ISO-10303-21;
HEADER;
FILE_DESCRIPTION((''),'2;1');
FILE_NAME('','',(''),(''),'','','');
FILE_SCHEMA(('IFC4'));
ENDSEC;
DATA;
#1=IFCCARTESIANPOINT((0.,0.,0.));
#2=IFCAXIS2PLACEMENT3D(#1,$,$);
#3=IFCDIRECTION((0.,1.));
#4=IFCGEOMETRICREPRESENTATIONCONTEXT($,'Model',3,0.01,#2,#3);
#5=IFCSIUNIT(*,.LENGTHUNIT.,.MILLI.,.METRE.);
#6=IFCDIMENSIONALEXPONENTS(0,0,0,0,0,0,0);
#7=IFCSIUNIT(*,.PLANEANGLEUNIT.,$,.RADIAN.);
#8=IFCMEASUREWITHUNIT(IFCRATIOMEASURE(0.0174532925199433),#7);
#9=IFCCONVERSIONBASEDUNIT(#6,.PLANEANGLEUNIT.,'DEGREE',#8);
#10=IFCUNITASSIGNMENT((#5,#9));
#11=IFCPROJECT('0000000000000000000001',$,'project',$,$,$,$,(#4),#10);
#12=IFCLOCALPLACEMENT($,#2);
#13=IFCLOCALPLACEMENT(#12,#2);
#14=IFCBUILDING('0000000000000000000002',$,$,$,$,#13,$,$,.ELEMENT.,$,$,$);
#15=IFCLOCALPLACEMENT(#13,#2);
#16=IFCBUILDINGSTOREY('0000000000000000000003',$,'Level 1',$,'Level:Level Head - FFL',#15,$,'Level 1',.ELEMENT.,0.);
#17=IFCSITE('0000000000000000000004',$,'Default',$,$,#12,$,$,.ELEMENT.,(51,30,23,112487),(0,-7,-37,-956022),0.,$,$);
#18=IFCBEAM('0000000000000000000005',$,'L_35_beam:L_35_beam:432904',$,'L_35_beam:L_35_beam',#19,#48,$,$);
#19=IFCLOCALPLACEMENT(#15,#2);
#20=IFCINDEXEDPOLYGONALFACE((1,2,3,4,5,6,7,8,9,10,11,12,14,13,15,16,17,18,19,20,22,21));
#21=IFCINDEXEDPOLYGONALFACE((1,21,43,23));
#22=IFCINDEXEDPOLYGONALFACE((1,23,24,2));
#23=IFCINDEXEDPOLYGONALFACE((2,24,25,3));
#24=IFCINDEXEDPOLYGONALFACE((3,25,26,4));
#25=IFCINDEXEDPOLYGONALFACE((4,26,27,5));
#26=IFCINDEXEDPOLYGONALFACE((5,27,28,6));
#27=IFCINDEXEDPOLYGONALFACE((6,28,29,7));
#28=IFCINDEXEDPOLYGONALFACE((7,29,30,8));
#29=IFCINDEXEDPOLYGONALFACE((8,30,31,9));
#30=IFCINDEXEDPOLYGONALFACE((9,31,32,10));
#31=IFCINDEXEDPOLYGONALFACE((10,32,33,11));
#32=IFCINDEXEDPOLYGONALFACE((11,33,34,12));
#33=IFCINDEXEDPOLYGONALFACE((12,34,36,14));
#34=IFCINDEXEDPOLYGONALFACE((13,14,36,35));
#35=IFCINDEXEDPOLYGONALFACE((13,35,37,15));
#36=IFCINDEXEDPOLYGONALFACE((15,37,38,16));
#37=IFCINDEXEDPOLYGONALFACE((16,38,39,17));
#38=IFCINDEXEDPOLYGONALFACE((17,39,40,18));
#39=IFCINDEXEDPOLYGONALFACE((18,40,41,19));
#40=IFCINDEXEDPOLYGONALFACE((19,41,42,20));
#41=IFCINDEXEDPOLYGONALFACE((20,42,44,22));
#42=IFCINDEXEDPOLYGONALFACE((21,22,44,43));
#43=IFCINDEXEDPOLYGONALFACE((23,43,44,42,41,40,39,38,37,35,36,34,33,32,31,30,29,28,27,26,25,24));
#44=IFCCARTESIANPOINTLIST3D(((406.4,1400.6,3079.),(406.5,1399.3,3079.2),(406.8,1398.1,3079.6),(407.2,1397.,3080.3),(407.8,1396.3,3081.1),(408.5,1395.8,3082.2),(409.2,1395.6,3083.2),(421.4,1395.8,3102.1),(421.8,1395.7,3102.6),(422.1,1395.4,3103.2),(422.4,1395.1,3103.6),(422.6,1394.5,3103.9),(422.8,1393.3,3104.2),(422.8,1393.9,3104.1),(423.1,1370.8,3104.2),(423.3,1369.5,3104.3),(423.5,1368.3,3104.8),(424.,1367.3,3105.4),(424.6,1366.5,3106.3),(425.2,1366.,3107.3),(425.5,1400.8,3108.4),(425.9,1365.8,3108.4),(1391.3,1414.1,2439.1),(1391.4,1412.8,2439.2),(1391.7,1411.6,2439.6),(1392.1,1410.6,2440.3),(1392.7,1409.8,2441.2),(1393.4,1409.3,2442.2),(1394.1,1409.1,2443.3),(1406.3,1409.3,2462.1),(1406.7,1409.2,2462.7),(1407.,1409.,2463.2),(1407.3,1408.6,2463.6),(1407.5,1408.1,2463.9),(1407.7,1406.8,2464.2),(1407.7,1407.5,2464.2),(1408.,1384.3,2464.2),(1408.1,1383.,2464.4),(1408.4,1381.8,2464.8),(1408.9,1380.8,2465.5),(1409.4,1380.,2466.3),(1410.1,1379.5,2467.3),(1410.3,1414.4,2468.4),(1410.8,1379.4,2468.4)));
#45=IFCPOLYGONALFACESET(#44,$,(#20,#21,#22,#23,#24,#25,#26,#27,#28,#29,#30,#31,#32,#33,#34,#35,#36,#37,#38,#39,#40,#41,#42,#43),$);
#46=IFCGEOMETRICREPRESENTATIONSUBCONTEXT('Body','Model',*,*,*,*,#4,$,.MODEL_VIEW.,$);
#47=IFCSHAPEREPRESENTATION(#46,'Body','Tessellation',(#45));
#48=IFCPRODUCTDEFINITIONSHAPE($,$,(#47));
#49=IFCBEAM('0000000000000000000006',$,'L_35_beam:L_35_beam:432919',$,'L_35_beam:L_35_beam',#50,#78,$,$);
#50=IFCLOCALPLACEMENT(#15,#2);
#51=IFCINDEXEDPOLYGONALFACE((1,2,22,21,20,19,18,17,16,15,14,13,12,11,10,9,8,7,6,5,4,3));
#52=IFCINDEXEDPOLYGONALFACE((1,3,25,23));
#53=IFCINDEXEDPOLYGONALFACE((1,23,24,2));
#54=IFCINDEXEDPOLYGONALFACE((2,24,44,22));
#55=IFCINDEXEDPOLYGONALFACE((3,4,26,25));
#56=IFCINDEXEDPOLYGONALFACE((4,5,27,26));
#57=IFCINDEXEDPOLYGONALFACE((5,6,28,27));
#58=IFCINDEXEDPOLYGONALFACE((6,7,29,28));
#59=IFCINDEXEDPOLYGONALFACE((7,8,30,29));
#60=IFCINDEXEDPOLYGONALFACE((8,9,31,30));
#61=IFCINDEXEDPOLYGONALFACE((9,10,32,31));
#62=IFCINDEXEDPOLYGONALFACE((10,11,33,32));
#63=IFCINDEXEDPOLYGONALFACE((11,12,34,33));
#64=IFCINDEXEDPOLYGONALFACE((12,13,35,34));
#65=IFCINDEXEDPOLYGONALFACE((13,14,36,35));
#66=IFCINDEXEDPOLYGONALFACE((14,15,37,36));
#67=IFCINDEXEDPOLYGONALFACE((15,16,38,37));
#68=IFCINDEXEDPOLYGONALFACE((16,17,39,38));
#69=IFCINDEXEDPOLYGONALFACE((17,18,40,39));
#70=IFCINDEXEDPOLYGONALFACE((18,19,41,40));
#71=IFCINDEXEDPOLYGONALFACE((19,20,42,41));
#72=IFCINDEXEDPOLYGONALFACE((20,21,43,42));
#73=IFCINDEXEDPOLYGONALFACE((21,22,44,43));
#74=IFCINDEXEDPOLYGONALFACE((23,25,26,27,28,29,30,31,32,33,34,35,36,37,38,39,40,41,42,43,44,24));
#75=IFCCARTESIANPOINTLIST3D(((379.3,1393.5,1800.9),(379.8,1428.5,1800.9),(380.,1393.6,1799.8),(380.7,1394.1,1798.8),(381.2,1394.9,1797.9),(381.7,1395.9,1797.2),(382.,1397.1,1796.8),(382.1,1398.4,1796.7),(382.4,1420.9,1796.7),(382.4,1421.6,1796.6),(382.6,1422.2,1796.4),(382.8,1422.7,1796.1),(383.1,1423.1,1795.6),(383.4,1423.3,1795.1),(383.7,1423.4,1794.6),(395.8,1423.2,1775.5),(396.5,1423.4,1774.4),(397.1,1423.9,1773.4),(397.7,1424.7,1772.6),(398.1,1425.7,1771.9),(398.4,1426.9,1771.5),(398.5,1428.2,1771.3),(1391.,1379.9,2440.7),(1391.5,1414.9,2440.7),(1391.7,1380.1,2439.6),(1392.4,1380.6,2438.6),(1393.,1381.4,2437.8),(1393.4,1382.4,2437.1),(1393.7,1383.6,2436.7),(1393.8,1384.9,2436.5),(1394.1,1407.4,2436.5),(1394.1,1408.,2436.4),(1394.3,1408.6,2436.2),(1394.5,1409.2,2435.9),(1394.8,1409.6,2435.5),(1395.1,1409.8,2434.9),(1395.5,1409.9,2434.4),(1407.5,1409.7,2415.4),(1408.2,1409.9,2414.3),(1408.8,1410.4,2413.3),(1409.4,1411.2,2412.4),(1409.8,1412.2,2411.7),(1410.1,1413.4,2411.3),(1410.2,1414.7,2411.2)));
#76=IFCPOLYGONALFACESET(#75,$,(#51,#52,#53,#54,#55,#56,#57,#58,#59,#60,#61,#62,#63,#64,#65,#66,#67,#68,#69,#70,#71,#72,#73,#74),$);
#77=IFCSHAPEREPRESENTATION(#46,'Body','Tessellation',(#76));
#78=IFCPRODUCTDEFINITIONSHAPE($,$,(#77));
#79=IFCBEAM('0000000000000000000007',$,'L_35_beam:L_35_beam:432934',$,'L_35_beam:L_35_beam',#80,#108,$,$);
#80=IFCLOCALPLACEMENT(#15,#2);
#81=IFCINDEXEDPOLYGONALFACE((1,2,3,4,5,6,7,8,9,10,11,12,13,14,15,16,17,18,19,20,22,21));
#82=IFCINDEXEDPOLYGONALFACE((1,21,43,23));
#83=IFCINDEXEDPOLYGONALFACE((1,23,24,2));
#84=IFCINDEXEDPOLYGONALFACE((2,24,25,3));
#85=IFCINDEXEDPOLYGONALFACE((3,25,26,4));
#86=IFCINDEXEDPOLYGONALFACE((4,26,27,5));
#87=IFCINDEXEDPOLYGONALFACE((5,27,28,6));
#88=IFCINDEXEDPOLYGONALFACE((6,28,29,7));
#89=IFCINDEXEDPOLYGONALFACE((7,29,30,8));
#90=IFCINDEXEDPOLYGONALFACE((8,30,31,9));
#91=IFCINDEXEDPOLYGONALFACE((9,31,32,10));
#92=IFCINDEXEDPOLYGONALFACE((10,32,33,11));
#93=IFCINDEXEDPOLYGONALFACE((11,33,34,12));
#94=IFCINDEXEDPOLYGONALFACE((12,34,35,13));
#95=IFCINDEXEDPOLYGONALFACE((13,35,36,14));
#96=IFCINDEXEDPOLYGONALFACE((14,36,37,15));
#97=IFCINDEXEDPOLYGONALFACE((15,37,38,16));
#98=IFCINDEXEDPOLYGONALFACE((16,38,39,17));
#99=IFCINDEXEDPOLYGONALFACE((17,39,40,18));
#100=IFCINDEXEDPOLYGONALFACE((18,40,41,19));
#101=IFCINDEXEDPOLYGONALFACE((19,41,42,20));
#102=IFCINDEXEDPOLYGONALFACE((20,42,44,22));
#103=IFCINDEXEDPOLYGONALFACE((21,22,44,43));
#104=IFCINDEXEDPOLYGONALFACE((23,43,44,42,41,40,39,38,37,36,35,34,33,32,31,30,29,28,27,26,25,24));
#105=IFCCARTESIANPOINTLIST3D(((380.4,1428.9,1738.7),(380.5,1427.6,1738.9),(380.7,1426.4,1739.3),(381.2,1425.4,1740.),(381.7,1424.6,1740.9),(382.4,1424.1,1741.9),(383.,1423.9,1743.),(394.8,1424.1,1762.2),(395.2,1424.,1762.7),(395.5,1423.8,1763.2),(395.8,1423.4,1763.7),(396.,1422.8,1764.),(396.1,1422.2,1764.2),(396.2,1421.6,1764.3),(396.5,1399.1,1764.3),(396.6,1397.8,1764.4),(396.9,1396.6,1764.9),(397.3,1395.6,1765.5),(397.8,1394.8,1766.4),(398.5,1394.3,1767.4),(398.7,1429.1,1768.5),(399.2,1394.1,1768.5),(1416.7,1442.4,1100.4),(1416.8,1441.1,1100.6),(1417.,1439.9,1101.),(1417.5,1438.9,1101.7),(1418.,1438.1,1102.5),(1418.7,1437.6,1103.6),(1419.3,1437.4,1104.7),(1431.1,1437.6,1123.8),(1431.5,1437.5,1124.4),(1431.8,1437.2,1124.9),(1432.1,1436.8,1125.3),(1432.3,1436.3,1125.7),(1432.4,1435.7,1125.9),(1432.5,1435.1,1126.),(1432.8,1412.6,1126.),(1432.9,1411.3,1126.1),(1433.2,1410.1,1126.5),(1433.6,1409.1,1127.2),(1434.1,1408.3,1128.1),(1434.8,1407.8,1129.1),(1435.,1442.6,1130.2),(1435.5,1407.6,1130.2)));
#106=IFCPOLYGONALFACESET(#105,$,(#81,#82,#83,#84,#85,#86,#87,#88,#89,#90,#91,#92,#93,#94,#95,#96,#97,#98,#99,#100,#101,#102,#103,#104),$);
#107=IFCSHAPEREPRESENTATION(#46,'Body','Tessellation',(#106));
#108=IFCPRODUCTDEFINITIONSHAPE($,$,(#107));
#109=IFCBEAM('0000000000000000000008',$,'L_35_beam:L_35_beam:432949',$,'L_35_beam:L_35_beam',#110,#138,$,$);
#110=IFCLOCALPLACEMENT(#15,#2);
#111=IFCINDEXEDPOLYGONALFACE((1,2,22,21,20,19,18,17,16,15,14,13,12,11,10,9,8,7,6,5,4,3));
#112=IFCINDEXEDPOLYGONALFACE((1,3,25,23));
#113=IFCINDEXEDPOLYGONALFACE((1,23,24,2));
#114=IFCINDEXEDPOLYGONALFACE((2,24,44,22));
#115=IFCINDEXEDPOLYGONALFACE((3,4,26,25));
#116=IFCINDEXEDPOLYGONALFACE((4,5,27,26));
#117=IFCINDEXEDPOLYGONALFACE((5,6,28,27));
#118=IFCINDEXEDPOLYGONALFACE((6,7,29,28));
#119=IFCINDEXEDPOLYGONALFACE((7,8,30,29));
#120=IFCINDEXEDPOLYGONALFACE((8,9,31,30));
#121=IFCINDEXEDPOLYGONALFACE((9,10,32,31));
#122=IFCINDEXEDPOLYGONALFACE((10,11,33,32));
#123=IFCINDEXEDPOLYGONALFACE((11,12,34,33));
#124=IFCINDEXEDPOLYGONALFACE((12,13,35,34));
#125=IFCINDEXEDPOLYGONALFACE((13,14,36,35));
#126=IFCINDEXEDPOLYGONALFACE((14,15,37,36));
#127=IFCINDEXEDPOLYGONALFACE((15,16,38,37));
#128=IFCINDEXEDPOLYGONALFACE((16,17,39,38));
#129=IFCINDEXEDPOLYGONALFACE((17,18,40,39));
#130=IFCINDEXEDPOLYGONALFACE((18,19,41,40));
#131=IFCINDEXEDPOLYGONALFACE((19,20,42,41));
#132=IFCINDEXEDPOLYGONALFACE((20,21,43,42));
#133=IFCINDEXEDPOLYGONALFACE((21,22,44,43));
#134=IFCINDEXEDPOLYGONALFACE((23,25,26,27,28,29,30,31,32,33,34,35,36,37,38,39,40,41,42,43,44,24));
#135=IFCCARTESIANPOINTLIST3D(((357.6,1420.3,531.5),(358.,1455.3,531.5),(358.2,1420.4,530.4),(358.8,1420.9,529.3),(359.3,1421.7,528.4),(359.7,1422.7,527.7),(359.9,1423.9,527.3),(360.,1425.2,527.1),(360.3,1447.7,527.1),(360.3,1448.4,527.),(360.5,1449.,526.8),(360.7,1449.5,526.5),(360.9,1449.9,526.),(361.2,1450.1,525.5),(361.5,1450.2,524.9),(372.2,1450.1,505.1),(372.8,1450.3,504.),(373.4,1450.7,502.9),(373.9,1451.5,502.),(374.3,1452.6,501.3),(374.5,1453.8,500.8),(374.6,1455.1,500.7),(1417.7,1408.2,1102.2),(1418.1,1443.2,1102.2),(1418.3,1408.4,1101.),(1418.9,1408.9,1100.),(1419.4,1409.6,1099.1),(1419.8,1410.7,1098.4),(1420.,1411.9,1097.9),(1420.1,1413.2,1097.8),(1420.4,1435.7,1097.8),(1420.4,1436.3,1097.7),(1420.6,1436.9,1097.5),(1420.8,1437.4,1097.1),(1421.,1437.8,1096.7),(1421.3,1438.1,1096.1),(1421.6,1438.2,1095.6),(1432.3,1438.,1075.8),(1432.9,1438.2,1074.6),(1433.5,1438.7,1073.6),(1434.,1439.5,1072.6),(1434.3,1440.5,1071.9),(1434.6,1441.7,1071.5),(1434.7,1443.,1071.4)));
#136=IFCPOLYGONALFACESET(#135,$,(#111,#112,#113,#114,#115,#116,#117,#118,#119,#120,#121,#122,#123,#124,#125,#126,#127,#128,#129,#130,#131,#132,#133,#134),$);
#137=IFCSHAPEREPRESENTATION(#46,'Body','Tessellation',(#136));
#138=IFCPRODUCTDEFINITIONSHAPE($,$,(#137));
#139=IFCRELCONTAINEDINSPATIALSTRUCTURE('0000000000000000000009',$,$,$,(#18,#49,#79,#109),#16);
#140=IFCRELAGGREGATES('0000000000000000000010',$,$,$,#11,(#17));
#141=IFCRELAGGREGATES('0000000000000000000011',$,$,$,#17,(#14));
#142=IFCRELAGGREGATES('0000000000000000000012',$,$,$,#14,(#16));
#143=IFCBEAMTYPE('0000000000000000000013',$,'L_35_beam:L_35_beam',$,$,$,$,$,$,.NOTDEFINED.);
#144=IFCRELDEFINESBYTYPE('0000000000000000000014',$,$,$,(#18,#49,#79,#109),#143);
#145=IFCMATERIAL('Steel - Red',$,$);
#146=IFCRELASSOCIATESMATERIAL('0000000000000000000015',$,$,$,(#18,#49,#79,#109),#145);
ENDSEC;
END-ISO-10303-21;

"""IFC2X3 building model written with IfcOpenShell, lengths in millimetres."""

from ifc_helpers import new_model, entity, si_unit, converted_unit, direction, frame, frame_2d, origin, place, context, subcontext, project, spatial, polyline, circle_curve, parameter, trimmed, segment, composite_curve, outline, extrude, material, type_object, element, save


model = new_model("IFC2X3")

# Units and contexts
model_context = context("Model", 3, precision=0.01, world=origin(), true_north=direction((0.0, 1.0)))
body_context = subcontext(model_context, "Body", "Model", "MODEL_VIEW")
ifc_project = project(units=[si_unit("LENGTHUNIT", "METRE", prefix="MILLI"), converted_unit("PLANEANGLEUNIT", "DEGREE", entity("IfcRatioMeasure", 0.0174532925199433), si_unit("PLANEANGLEUNIT", "RADIAN"), dimensions=[0, 0, 0, 0, 0, 0, 0])], contexts=[model_context])

# Site, building, storey
site_placement = place(None, origin())
site = spatial("IfcSite", under=ifc_project, at=site_placement, Name="Default", CompositionType="ELEMENT", RefLatitude=(51, 30, 23, 112487), RefLongitude=(0, -7, -37, -956022), RefElevation=0.0)
building_placement = place(site_placement, origin())
building = spatial("IfcBuilding", under=site, at=building_placement, CompositionType="ELEMENT")
storey_placement = place(building_placement, origin())
storey = spatial("IfcBuildingStorey", under=building, at=storey_placement, Name="Level 1", ObjectType="Level:Level Head - FFL", LongName="Level 1", CompositionType="ELEMENT", Elevation=0.0)

# Beams
ifc_material_1 = material(Name="Steel - Red")
beam_type = type_object("IfcBeamType", Name="L_35_beam:L_35_beam", PredefinedType="NOTDEFINED")
beam_1_placement = place(storey_placement, frame((391.6, 1408.4, 3109.4), z_axis=(0.544781, 0.00748, 0.838545), x_axis=(0.838466, 0.011512, -0.544833)))
element("IfcBeam", 1, at=beam_1_placement, inside=storey, type_object=beam_type, material=ifc_material_1, Name="L_35_beam:L_35_beam:432904", ObjectType="L_35_beam:L_35_beam", context=body_context, shape_type="SweptSolid", body=[
    extrude(outline(composite_curve([segment(polyline([(-23.2, -11.8), (11.8, -11.8)]), True, "CONTINUOUS"), segment(polyline([(11.8, -11.8), (11.8, 23.2)]), True, "CONTINUOUS"), segment(trimmed(circle_curve(frame_2d((11.8, 18.2), x_axis=(0.0, 1.0)), 5.0), [parameter(0.0)], [parameter(90.0)], True, "PARAMETER"), True, "CONTINUOUS"), segment(polyline([(6.8, 18.2), (6.8, -4.3)]), True, "CONTINUOUS"), segment(trimmed(circle_curve(frame_2d((4.3, -4.3), x_axis=(1.0, 0.0)), 2.5), [parameter(270.0)], [parameter(0.0)], True, "PARAMETER"), False, "CONTINUOUS"), segment(polyline([(4.3, -6.8), (-18.2, -6.8)]), True, "CONTINUOUS"), segment(trimmed(circle_curve(frame_2d((-18.2, -11.8), x_axis=(0.0, 1.0)), 5.0), [parameter(0.0)], [parameter(90.0)], True, "PARAMETER"), True, "CONTINUOUS")], self_intersect=False)), frame((28.8, -19.8, 5.7), z_axis=(1.0, 0.0, 0.0), x_axis=(0.0, 0.0, 1.0)), (0.0, 0.0, 1.0), 1174.6),
])
beam_2_placement = place(storey_placement, frame((363.3, 1436.7, 1769.7), z_axis=(-0.534423, 0.007141, 0.845187), x_axis=(0.845111, -0.011293, 0.534471)))
element("IfcBeam", 2, at=beam_2_placement, inside=storey, type_object=beam_type, material=ifc_material_1, Name="L_35_beam:L_35_beam:432919", ObjectType="L_35_beam:L_35_beam", context=body_context, shape_type="SweptSolid", body=[
    extrude(outline(composite_curve([segment(polyline([(-23.2, -11.8), (11.8, -11.8)]), True, "CONTINUOUS"), segment(polyline([(11.8, -11.8), (11.8, 23.2)]), True, "CONTINUOUS"), segment(trimmed(circle_curve(frame_2d((11.8, 18.2), x_axis=(0.0, 1.0)), 5.0), [parameter(0.0)], [parameter(90.0)], True, "PARAMETER"), True, "CONTINUOUS"), segment(polyline([(6.8, 18.2), (6.8, -4.3)]), True, "CONTINUOUS"), segment(trimmed(circle_curve(frame_2d((4.3, -4.3), x_axis=(1.0, 0.0)), 2.5), [parameter(270.0)], [parameter(0.0)], True, "PARAMETER"), False, "CONTINUOUS"), segment(polyline([(4.3, -6.8), (-18.2, -6.8)]), True, "CONTINUOUS"), segment(trimmed(circle_curve(frame_2d((-18.2, -11.8), x_axis=(0.0, 1.0)), 5.0), [parameter(0.0)], [parameter(90.0)], True, "PARAMETER"), True, "CONTINUOUS")], self_intersect=False)), frame((30.7, -19.8, 5.7), z_axis=(1.0, 0.0, 0.0), x_axis=(0.0, 0.0, 1.0)), (0.0, 0.0, 1.0), 1197.1),
])
beam_3_placement = place(storey_placement, frame((363.3, 1436.7, 1769.7), z_axis=(0.524377, 0.006825, 0.851459), x_axis=(0.851387, 0.011081, -0.524421)))
element("IfcBeam", 3, at=beam_3_placement, inside=storey, type_object=beam_type, material=ifc_material_1, Name="L_35_beam:L_35_beam:432934", ObjectType="L_35_beam:L_35_beam", context=body_context, shape_type="SweptSolid", body=[
    extrude(outline(composite_curve([segment(polyline([(-23.2, -11.8), (11.8, -11.8)]), True, "CONTINUOUS"), segment(polyline([(11.8, -11.8), (11.8, 23.2)]), True, "CONTINUOUS"), segment(trimmed(circle_curve(frame_2d((11.8, 18.2), x_axis=(0.0, 1.0)), 5.0), [parameter(0.0)], [parameter(90.0)], True, "PARAMETER"), True, "CONTINUOUS"), segment(polyline([(6.8, 18.2), (6.8, -4.3)]), True, "CONTINUOUS"), segment(trimmed(circle_curve(frame_2d((4.3, -4.3), x_axis=(1.0, 0.0)), 2.5), [parameter(270.0)], [parameter(0.0)], True, "PARAMETER"), False, "CONTINUOUS"), segment(polyline([(4.3, -6.8), (-18.2, -6.8)]), True, "CONTINUOUS"), segment(trimmed(circle_curve(frame_2d((-18.2, -11.8), x_axis=(0.0, 1.0)), 5.0), [parameter(0.0)], [parameter(90.0)], True, "PARAMETER"), True, "CONTINUOUS")], self_intersect=False)), frame((30.6, -19.8, 5.7), z_axis=(1.0, 0.0, 0.0), x_axis=(0.0, 0.0, 1.0)), (0.0, 0.0, 1.0), 1217.2),
])
beam_4_placement = place(storey_placement, frame((336.5, 1463.5, 500.0), z_axis=(-0.473951, 0.005391, 0.880535), x_axis=(0.880478, -0.010015, 0.473982)))
element("IfcBeam", 4, at=beam_4_placement, inside=storey, type_object=beam_type, material=ifc_material_1, Name="L_35_beam:L_35_beam:432949", ObjectType="L_35_beam:L_35_beam", context=body_context, shape_type="SweptSolid", body=[
    extrude(outline(composite_curve([segment(polyline([(-23.2, -11.8), (11.8, -11.8)]), True, "CONTINUOUS"), segment(polyline([(11.8, -11.8), (11.8, 23.2)]), True, "CONTINUOUS"), segment(trimmed(circle_curve(frame_2d((11.8, 18.2), x_axis=(0.0, 1.0)), 5.0), [parameter(0.0)], [parameter(90.0)], True, "PARAMETER"), True, "CONTINUOUS"), segment(polyline([(6.8, 18.2), (6.8, -4.3)]), True, "CONTINUOUS"), segment(trimmed(circle_curve(frame_2d((4.3, -4.3), x_axis=(1.0, 0.0)), 2.5), [parameter(270.0)], [parameter(0.0)], True, "PARAMETER"), False, "CONTINUOUS"), segment(polyline([(4.3, -6.8), (-18.2, -6.8)]), True, "CONTINUOUS"), segment(trimmed(circle_curve(frame_2d((-18.2, -11.8), x_axis=(0.0, 1.0)), 5.0), [parameter(0.0)], [parameter(90.0)], True, "PARAMETER"), True, "CONTINUOUS")], self_intersect=False)), frame((34.0, -19.8, 5.7), z_axis=(1.0, 0.0, 0.0), x_axis=(0.0, 0.0, 1.0)), (0.0, 0.0, 1.0), 1204.0),
])

save(model, "model.ifc")
